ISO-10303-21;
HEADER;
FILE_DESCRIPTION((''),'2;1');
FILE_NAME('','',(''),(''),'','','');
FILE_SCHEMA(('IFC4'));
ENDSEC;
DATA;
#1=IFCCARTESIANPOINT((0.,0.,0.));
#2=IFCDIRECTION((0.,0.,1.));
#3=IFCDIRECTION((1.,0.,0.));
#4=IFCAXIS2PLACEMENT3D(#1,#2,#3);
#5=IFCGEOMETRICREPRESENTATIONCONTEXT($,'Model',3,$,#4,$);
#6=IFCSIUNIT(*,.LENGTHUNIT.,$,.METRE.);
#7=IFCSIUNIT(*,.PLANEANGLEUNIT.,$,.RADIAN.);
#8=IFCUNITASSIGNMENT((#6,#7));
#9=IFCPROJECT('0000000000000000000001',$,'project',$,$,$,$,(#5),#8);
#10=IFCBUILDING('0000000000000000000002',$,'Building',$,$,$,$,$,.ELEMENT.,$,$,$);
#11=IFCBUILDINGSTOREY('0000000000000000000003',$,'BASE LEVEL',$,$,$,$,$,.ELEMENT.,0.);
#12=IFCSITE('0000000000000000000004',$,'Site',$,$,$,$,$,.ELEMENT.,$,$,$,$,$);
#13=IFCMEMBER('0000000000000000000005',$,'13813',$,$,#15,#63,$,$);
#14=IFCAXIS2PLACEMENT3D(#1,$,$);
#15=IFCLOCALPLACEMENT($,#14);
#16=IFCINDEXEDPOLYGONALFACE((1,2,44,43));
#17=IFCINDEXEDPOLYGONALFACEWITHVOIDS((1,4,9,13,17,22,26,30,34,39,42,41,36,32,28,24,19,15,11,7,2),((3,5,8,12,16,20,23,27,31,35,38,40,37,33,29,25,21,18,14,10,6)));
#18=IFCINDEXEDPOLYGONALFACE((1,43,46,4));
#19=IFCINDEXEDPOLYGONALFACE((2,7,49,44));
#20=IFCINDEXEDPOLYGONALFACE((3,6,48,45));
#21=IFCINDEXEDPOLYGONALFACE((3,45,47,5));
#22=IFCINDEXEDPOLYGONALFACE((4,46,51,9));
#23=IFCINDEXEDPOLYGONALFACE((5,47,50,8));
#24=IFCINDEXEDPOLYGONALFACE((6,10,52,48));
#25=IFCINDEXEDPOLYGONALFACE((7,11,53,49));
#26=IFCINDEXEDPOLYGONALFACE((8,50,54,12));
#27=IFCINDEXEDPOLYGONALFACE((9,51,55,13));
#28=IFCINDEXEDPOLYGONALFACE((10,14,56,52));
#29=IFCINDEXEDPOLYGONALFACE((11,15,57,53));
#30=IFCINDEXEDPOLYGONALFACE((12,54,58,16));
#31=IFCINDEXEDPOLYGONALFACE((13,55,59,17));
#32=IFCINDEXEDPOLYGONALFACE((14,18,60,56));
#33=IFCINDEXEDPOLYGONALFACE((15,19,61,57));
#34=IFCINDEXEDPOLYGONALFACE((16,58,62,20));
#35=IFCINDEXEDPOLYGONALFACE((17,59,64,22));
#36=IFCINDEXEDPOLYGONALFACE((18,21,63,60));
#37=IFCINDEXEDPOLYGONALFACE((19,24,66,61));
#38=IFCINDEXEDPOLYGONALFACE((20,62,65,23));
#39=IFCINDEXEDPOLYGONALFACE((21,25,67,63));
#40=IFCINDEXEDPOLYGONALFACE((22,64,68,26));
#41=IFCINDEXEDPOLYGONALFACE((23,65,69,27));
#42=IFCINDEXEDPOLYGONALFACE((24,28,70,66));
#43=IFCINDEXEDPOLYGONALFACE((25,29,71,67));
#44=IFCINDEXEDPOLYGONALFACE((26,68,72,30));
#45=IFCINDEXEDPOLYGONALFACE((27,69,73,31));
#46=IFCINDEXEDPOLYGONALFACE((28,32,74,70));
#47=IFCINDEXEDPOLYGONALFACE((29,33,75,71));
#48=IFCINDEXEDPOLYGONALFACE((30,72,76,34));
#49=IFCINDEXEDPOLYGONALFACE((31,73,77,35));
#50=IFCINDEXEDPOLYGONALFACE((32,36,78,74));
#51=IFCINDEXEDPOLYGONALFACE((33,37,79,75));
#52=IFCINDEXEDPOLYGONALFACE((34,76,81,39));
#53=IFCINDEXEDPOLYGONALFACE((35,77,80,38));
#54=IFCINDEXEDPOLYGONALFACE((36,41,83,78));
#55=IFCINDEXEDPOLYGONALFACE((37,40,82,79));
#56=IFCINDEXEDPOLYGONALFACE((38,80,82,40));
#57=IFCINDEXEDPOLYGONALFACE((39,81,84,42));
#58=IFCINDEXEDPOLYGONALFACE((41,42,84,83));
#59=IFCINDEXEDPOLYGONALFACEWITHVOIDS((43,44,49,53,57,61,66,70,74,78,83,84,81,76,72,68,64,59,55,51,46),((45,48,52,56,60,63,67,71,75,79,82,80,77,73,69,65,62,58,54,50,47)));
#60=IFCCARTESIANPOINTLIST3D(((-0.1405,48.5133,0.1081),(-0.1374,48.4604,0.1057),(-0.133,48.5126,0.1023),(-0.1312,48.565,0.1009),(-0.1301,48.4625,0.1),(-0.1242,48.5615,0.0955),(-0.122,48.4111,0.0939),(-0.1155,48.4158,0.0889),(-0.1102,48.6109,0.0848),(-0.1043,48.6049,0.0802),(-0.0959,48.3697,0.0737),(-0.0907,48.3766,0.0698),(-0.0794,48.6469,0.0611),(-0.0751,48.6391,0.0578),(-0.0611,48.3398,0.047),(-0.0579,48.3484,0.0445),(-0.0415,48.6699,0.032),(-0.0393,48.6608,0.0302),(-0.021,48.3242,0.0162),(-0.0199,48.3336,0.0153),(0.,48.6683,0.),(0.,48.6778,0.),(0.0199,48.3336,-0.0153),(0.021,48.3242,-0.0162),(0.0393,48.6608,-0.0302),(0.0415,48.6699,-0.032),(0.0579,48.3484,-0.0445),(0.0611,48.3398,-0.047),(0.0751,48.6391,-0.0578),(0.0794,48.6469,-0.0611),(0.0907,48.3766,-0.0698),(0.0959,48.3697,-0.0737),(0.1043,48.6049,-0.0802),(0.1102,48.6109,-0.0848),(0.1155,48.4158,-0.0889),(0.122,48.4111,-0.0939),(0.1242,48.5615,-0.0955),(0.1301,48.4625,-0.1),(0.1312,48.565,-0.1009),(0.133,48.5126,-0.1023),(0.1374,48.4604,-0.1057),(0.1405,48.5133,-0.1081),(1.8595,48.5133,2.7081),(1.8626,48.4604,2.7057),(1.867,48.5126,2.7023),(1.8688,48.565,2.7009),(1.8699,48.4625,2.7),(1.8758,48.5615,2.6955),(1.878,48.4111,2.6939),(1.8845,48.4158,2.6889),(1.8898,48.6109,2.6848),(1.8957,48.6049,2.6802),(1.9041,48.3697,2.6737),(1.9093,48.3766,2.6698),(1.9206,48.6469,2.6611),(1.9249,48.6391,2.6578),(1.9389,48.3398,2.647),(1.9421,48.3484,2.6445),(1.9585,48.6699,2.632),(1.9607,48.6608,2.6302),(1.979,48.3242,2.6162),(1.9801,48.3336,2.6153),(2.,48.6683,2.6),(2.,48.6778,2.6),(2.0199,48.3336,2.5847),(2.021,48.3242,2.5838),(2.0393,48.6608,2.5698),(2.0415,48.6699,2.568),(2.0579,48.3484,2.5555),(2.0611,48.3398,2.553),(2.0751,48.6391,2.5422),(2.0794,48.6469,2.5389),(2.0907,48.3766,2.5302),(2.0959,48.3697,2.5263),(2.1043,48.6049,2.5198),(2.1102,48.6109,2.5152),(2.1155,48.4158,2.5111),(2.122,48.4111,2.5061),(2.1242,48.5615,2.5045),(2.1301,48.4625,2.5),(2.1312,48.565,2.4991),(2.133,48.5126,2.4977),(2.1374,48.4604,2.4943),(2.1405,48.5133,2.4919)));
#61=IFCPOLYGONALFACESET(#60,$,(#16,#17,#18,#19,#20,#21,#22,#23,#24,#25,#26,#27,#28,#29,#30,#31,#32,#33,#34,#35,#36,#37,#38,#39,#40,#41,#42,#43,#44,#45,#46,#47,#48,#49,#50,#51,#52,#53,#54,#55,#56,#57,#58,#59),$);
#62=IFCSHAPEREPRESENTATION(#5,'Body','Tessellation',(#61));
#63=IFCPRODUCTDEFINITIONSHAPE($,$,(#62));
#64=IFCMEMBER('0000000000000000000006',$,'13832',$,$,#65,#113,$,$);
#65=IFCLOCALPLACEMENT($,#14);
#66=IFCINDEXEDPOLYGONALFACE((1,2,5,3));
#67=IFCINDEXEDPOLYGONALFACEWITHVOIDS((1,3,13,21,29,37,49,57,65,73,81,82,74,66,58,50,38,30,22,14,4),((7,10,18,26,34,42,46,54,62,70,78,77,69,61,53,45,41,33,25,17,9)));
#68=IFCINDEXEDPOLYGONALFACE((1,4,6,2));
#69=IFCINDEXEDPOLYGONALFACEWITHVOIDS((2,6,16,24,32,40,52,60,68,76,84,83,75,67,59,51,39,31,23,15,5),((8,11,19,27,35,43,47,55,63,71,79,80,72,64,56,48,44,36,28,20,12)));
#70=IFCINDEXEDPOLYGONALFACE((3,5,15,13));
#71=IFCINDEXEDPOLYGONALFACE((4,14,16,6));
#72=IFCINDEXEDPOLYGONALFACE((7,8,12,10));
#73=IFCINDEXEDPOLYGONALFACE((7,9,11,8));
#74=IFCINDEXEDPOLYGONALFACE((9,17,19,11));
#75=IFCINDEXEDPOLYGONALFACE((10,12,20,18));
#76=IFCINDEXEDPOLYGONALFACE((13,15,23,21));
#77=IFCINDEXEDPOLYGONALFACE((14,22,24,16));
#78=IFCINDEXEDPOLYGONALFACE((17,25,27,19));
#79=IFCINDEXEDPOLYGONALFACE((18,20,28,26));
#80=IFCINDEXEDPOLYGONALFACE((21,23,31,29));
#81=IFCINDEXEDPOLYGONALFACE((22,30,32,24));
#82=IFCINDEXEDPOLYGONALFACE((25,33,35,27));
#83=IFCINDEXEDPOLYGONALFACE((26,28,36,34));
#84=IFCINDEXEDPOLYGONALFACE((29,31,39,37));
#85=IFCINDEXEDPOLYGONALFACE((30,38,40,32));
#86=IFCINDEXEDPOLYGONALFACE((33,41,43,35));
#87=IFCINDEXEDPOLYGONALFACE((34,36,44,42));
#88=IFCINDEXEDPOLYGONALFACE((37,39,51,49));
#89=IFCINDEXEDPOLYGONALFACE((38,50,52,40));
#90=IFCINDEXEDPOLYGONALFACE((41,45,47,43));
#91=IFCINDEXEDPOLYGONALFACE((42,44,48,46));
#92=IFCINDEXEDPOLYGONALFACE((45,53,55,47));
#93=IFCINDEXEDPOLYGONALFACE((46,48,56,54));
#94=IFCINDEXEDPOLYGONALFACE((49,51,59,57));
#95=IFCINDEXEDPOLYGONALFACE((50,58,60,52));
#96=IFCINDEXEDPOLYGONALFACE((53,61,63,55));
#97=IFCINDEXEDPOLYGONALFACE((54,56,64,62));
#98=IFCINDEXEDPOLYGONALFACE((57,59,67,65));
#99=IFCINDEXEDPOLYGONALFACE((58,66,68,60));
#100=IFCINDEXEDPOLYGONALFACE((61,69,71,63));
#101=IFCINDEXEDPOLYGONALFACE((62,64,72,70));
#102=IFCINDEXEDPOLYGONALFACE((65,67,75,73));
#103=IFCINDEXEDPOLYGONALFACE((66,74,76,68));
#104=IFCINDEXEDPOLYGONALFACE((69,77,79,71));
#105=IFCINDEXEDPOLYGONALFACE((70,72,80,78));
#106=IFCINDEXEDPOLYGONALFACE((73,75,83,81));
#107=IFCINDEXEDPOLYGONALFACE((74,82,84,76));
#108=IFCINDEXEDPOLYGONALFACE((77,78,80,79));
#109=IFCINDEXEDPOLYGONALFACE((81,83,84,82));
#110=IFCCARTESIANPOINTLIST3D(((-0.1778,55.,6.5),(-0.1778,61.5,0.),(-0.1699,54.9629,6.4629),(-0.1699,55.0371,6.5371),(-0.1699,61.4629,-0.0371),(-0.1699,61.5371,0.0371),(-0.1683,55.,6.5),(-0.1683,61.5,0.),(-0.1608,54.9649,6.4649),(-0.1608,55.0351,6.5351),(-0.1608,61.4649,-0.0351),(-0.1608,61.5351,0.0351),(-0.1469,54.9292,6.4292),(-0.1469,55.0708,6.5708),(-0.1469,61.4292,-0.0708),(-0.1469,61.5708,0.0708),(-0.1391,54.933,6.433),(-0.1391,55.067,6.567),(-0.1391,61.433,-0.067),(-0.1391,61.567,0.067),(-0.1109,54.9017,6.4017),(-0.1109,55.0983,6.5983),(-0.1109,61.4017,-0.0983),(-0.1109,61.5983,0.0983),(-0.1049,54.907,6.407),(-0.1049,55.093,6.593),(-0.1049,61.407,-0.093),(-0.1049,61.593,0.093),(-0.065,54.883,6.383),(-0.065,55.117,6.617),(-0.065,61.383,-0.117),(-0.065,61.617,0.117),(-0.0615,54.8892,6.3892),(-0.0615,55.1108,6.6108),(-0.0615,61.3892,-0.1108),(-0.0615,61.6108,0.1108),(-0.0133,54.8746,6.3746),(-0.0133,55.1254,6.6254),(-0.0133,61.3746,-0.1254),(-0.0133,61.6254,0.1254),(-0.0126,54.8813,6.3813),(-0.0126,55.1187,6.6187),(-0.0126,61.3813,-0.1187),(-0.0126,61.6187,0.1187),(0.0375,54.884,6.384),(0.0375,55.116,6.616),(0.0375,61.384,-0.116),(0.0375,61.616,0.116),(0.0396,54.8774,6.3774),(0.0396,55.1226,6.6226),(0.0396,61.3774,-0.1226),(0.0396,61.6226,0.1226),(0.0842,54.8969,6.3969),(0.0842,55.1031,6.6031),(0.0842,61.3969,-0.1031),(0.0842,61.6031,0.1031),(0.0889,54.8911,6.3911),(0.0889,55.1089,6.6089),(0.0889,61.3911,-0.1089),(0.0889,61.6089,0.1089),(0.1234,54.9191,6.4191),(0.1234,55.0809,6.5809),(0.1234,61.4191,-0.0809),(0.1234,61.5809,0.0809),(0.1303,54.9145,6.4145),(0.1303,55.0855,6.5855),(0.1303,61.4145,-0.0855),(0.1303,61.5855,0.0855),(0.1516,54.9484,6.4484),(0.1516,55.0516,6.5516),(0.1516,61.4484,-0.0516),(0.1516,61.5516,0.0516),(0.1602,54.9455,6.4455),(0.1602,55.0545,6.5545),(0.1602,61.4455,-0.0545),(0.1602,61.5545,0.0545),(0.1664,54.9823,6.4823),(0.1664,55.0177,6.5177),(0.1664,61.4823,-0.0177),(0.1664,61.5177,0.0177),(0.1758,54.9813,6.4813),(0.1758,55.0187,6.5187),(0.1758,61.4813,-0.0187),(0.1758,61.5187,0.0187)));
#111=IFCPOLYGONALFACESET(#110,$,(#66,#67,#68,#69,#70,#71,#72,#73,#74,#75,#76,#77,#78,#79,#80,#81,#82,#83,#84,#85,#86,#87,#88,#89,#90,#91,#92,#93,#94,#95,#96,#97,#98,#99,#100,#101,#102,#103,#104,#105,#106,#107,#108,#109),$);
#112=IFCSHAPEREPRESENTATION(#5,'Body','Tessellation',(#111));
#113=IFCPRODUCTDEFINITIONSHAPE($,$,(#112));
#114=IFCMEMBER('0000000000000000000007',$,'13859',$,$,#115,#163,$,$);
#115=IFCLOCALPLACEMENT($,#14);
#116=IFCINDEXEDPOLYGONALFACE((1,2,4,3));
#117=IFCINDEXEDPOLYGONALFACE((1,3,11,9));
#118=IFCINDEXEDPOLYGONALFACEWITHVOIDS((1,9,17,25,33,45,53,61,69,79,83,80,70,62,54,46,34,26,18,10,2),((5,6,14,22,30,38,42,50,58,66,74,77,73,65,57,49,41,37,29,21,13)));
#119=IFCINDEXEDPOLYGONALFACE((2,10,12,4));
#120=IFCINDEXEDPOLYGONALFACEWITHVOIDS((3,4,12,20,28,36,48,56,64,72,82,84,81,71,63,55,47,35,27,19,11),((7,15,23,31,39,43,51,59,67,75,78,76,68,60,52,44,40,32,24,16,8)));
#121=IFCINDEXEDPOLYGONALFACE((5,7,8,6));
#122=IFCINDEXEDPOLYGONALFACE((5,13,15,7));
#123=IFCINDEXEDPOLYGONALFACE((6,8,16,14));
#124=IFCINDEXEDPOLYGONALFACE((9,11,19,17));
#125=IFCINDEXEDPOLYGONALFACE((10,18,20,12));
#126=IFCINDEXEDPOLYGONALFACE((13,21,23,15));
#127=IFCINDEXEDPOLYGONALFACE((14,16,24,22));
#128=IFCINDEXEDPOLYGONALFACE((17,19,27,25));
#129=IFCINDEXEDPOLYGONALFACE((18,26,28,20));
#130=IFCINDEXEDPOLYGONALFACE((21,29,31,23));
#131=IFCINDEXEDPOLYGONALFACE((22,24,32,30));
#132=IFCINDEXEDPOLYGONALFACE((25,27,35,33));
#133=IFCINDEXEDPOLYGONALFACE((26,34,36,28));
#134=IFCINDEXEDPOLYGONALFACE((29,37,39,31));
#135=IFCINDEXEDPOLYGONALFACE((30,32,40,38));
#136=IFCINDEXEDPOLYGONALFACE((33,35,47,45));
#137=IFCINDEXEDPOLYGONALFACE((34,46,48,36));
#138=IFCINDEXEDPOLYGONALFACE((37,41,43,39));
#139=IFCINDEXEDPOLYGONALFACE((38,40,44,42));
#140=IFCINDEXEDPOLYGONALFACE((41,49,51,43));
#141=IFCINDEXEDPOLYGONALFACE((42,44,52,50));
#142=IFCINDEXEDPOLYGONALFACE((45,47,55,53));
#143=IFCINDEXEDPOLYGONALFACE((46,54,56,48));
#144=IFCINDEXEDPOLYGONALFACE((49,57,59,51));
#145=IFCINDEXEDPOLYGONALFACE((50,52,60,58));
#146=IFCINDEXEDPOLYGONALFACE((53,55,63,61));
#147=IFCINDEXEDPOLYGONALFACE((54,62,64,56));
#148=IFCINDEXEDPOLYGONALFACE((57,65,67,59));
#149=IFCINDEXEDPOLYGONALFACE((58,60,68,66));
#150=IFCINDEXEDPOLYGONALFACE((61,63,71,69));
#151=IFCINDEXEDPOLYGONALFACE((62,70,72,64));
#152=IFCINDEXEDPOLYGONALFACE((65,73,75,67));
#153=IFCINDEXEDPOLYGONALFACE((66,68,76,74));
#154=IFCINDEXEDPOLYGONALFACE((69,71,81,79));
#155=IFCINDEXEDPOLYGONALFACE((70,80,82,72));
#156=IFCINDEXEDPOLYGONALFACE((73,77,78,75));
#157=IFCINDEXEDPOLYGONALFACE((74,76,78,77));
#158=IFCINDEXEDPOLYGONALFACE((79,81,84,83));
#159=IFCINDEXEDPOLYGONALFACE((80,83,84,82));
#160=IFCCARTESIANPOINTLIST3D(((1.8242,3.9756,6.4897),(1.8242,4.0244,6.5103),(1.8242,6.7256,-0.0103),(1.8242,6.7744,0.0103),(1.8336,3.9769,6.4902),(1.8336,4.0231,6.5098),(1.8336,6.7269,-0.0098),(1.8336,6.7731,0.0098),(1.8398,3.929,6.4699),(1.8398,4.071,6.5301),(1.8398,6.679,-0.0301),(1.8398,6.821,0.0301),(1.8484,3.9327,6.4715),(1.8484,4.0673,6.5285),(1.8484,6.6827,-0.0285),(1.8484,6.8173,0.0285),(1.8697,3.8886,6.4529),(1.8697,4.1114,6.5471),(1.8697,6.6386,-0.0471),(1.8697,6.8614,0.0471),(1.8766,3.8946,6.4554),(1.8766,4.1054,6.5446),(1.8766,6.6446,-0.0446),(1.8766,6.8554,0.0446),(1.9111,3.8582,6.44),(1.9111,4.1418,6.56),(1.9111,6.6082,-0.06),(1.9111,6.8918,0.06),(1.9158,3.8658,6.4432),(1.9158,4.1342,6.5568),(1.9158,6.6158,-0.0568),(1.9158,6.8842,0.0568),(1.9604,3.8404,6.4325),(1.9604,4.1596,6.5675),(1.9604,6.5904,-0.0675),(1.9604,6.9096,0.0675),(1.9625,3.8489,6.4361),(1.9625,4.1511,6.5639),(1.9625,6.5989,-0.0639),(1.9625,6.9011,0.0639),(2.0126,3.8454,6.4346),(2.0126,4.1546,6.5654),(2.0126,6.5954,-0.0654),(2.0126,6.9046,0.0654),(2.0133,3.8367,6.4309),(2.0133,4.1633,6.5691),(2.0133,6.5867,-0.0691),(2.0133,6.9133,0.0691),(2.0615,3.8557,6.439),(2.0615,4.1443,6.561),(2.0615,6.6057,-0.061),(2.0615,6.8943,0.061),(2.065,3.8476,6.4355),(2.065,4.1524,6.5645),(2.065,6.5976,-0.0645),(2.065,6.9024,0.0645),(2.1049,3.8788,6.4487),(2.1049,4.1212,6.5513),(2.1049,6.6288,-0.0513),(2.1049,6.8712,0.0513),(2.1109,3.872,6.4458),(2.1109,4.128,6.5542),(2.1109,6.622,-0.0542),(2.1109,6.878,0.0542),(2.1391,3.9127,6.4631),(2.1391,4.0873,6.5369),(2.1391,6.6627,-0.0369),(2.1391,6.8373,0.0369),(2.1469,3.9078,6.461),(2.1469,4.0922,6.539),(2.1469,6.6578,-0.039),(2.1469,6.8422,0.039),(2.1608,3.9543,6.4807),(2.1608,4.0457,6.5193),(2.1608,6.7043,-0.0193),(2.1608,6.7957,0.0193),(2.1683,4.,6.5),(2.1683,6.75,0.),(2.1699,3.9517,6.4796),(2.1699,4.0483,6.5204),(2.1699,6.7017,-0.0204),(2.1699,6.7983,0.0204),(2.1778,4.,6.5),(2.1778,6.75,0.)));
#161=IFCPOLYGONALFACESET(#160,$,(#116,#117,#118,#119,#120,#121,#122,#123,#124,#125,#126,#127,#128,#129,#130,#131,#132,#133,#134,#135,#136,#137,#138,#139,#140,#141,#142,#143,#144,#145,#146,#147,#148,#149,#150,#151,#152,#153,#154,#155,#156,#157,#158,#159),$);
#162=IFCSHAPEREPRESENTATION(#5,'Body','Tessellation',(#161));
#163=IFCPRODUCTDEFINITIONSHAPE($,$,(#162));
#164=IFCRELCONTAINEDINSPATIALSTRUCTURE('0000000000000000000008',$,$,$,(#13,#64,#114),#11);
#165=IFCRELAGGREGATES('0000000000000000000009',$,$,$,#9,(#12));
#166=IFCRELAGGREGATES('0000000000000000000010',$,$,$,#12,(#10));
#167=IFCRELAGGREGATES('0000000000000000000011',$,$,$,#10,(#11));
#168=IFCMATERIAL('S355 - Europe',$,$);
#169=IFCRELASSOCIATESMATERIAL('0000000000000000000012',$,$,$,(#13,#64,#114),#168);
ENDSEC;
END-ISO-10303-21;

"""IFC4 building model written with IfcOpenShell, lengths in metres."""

from ifc_helpers import new_model, si_unit, frame, origin_with_axes, origin_2d_with_axis, place, context, project, spatial, hollow_circle, extrude, material, material_profile, profile_set, profile_usage, element, save


model = new_model("IFC4")

# Units and contexts
model_context = context("Model", 3, world=origin_with_axes())
ifc_project = project(units=[si_unit("LENGTHUNIT", "METRE"), si_unit("PLANEANGLEUNIT", "RADIAN")], contexts=[model_context])

# Site, building, storey
site = spatial("IfcSite", under=ifc_project, Name="Site", CompositionType="ELEMENT")
building = spatial("IfcBuilding", under=site, Name="Building", CompositionType="ELEMENT")
storey = spatial("IfcBuildingStorey", under=building, Name="BASE LEVEL", CompositionType="ELEMENT", Elevation=0.0)

# Shared definitions
ifc_material = material(Name="S355 - Europe")

# Members
ifc_material_profile_1 = material_profile(ifc_material, hollow_circle(Radius=0.1778, WallThickness=0.0095, at=origin_2d_with_axis()))
ifc_profile_set_1 = profile_set([ifc_material_profile_1])
ifc_profile_usage_1 = profile_usage(ifc_profile_set_1, cardinal=10)
member_1_placement = place(None, frame((0.0, 48.5, 0.0), z_axis=(0.609711, 0.0, 0.792624), x_axis=(0.0, 1.0, 0.0)))
element("IfcMember", 1, at=member_1_placement, inside=storey, material=ifc_profile_usage_1, Name="13813", context=model_context, shape_type="SweptSolid", body=[
    extrude(hollow_circle(Radius=0.1778, WallThickness=0.0095, at=origin_2d_with_axis()), origin_with_axes(), (0.0, 0.0, 1.0), 3.2802),
])
ifc_material_profile_2 = material_profile(ifc_material, hollow_circle(Radius=0.1778, WallThickness=0.0095, at=origin_2d_with_axis()))
ifc_profile_set_2 = profile_set([ifc_material_profile_2])
ifc_profile_usage_2 = profile_usage(ifc_profile_set_2, cardinal=10)
member_2_placement = place(None, frame((0.0, 55.0, 6.5), z_axis=(0.0, 0.707107, -0.707107), x_axis=(-1.0, 0.0, 0.0)))
element("IfcMember", 2, at=member_2_placement, inside=storey, material=ifc_profile_usage_2, Name="13832", context=model_context, shape_type="SweptSolid", body=[
    extrude(hollow_circle(Radius=0.1778, WallThickness=0.0095, at=origin_2d_with_axis()), origin_with_axes(), (0.0, 0.0, 1.0), 9.1924),
])
ifc_material_profile_3 = material_profile(ifc_material, hollow_circle(Radius=0.1778, WallThickness=0.0095, at=origin_2d_with_axis()))
ifc_profile_set_3 = profile_set([ifc_material_profile_3])
ifc_profile_usage_3 = profile_usage(ifc_profile_set_3, cardinal=10)
member_3_placement = place(None, frame((2.0, 6.75, 0.0), z_axis=(0.0, -0.38964, 0.920967), x_axis=(1.0, 0.0, 0.0)))
element("IfcMember", 3, at=member_3_placement, inside=storey, material=ifc_profile_usage_3, Name="13859", context=model_context, shape_type="SweptSolid", body=[
    extrude(hollow_circle(Radius=0.1778, WallThickness=0.0095, at=origin_2d_with_axis()), origin_with_axes(), (0.0, 0.0, 1.0), 7.0578),
])

save(model, "model.ifc")
